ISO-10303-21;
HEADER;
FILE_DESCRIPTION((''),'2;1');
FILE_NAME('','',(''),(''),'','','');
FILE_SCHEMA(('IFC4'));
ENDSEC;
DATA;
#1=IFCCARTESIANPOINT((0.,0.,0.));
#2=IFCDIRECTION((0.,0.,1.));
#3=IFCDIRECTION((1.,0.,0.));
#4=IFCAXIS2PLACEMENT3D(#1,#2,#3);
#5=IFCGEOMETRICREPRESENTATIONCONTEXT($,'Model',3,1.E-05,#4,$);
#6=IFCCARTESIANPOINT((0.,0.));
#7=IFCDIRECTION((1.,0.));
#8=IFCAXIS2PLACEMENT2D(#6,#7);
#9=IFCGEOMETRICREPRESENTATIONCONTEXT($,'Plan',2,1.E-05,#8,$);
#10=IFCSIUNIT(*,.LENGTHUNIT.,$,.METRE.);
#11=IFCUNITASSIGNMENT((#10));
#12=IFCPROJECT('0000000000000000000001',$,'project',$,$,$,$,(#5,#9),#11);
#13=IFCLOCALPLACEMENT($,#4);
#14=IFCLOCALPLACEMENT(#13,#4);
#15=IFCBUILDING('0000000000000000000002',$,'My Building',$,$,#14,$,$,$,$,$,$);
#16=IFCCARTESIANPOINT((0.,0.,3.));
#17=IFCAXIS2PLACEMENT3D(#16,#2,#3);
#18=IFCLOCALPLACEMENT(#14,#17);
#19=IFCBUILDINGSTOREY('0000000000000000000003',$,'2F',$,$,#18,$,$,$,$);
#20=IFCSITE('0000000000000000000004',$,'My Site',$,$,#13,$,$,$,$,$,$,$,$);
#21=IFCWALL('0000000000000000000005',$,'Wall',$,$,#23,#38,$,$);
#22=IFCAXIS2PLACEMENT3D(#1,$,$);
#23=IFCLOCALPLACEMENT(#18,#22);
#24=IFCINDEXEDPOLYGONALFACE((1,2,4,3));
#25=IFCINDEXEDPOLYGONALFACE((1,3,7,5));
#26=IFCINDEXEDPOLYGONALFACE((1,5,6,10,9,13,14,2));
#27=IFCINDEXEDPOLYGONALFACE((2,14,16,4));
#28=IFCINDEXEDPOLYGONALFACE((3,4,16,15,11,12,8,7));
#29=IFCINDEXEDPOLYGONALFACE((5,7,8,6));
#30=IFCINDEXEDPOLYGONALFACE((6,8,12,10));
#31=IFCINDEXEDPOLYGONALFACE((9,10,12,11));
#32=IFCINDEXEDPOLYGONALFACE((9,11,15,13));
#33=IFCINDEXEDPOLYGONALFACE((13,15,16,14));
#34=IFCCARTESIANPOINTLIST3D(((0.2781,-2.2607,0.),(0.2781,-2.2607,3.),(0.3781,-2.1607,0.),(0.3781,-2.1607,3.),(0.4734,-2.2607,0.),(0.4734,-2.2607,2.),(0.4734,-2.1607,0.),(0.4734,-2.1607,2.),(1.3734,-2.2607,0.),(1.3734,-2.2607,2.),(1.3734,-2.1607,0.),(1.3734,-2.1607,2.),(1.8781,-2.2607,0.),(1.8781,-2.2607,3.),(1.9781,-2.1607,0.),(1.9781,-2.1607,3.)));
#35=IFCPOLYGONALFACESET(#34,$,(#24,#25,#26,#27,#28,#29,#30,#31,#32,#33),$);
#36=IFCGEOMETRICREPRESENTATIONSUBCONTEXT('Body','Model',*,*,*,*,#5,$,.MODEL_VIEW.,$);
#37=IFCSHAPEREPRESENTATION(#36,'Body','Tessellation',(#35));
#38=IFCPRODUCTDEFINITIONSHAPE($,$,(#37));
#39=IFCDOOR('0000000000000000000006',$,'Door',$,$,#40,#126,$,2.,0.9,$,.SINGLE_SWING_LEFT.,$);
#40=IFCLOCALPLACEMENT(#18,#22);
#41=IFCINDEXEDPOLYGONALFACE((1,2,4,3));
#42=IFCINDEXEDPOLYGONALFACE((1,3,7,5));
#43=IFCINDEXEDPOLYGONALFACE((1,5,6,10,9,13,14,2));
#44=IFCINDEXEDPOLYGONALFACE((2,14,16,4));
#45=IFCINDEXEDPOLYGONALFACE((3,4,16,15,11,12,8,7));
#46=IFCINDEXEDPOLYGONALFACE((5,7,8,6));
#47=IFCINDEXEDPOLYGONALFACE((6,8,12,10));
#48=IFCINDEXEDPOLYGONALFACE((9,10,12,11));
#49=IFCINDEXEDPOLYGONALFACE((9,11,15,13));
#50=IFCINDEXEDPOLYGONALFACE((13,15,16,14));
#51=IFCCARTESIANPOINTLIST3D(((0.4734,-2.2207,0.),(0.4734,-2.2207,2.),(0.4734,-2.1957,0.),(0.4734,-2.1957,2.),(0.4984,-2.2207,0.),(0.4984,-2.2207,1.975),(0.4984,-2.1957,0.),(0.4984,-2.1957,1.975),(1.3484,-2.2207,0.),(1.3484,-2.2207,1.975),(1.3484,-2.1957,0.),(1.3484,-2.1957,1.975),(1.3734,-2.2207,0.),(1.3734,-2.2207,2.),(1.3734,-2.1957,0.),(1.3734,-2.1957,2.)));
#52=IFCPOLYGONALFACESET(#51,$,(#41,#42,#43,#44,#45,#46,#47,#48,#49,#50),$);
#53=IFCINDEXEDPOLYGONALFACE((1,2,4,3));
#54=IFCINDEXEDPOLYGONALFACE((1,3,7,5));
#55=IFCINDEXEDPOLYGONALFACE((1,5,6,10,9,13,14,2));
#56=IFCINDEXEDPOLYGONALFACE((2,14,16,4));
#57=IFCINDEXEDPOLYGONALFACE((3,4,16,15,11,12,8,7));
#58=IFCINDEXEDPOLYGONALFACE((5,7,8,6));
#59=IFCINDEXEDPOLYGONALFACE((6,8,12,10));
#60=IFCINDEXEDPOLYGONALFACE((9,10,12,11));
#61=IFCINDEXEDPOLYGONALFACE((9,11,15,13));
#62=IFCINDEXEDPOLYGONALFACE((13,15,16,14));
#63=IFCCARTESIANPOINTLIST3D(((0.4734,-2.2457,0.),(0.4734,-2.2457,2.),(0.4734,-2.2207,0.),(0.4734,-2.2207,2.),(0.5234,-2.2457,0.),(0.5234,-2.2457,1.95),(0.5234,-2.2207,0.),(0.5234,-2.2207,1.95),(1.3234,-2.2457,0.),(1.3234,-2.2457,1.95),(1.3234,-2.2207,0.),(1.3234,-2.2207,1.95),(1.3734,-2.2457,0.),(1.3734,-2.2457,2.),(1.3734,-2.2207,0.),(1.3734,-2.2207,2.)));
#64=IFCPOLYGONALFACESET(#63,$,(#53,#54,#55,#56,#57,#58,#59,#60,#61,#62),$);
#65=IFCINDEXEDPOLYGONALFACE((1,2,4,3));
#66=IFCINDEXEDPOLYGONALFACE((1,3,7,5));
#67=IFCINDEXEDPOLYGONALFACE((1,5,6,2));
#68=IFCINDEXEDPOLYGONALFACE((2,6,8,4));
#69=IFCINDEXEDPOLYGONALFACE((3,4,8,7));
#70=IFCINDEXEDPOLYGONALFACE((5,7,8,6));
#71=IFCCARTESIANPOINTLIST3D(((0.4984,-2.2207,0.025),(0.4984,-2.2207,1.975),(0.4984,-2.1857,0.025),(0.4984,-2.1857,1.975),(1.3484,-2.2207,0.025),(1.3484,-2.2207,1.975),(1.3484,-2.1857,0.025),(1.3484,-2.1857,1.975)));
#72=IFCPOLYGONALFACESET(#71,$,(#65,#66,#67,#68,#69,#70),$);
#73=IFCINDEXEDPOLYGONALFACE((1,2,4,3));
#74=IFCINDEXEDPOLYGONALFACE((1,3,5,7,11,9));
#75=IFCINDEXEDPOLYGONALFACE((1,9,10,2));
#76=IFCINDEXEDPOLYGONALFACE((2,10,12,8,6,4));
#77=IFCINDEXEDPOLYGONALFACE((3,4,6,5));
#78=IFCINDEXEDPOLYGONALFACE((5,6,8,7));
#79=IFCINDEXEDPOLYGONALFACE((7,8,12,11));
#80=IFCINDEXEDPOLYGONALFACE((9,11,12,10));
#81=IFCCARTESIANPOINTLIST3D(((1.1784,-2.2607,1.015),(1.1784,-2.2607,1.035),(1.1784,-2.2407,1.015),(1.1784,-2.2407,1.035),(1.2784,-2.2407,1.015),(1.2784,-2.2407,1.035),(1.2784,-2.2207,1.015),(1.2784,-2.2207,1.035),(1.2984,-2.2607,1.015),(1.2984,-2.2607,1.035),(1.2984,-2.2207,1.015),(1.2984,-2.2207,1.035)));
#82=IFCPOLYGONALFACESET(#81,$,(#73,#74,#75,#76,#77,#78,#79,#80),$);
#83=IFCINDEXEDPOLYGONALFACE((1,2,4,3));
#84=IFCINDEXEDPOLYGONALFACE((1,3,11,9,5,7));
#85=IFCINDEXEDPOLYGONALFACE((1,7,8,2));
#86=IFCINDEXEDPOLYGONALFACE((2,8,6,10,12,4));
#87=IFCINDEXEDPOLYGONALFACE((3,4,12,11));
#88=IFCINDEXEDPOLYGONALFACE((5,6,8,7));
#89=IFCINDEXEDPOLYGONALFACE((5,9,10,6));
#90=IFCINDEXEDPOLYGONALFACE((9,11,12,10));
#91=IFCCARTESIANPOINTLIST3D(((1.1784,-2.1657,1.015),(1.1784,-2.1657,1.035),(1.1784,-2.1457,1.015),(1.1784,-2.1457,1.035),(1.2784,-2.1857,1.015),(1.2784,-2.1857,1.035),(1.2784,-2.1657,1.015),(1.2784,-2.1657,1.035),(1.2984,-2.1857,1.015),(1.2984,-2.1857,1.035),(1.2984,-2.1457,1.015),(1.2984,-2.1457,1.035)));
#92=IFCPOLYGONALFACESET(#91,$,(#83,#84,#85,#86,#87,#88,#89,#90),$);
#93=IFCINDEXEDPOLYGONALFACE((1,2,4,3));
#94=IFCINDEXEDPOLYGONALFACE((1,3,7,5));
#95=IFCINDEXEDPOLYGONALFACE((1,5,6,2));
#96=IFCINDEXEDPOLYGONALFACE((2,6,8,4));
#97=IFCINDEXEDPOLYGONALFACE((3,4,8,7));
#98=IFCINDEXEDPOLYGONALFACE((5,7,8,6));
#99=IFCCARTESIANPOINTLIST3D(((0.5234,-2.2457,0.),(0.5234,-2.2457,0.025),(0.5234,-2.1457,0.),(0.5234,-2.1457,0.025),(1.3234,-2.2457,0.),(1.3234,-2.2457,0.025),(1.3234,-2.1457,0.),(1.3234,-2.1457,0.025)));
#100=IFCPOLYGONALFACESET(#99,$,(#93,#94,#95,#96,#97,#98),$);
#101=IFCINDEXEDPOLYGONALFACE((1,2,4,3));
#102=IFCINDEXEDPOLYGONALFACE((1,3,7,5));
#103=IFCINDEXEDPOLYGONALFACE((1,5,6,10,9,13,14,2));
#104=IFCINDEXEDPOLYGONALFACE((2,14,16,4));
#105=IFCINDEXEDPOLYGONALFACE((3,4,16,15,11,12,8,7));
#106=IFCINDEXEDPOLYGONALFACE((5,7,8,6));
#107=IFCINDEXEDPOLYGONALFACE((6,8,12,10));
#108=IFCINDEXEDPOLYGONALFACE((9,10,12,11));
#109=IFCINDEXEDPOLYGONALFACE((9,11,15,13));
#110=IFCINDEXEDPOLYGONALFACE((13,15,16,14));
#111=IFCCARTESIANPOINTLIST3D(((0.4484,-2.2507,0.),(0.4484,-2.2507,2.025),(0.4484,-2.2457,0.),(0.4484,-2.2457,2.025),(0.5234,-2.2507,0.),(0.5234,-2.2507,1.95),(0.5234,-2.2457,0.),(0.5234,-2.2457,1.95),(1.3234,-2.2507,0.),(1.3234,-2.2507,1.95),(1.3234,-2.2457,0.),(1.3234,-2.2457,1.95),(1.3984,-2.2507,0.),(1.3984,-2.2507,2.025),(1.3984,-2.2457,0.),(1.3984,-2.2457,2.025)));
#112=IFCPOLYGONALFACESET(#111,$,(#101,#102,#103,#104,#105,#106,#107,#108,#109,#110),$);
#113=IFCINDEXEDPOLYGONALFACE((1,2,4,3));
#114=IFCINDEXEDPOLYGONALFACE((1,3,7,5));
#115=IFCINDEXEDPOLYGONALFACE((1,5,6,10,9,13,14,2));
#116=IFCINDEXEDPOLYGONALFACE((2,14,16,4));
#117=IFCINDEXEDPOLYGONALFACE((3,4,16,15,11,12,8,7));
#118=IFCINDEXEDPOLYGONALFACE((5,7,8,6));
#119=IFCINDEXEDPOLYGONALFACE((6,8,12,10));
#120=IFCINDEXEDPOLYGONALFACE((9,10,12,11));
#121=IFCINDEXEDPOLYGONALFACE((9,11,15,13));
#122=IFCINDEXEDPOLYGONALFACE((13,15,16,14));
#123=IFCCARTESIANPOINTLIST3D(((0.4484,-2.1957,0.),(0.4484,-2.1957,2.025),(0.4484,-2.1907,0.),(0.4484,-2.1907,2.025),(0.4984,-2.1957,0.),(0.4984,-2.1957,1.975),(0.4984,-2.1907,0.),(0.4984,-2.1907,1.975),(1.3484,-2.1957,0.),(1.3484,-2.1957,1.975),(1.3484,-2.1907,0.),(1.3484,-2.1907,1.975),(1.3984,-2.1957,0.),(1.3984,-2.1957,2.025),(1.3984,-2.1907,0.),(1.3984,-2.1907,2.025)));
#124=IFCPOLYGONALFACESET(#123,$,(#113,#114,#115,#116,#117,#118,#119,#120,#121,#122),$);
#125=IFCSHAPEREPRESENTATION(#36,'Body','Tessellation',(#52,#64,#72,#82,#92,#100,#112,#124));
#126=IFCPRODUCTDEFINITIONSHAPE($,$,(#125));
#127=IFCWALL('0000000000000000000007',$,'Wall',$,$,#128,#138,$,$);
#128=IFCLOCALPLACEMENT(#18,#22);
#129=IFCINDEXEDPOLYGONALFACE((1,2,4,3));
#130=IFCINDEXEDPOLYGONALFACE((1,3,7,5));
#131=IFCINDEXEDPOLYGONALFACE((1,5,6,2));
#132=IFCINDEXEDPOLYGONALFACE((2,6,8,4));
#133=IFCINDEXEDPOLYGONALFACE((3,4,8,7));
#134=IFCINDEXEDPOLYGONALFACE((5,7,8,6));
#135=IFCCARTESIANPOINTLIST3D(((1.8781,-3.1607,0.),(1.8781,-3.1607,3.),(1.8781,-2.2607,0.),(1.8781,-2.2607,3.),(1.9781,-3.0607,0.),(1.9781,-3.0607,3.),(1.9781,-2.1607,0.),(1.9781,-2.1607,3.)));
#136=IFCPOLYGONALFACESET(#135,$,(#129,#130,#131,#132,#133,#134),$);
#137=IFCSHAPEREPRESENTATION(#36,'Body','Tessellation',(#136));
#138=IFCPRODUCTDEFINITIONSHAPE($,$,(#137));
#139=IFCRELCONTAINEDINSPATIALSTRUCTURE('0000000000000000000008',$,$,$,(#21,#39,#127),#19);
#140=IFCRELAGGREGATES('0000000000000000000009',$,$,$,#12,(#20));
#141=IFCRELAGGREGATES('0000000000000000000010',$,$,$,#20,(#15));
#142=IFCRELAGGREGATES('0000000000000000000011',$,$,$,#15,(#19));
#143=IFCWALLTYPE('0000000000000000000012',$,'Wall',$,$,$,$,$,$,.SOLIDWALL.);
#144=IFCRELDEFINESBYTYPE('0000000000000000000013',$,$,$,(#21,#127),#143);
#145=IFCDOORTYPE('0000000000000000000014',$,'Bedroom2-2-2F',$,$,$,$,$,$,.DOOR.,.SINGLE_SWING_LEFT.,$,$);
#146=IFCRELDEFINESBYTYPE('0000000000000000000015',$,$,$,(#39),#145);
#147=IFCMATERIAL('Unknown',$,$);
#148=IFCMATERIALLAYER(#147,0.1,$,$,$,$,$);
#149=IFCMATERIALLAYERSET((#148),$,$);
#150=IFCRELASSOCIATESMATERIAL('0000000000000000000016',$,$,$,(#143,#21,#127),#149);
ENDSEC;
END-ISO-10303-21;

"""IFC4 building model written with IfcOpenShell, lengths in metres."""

from ifc_helpers import new_model, entity, si_unit, frame, origin_with_axes, origin_2d_with_axis, place, context, subcontext, project, spatial, line, indexed_curve, outline, extrude, shape, source, transform, mapped, material, layer, layer_set, layer_usage, type_object, type_shapes, element, fill, save


model = new_model("IFC4")

# Units and contexts
model_context = context("Model", 3, precision=1e-05, world=origin_with_axes())
plan_context = context("Plan", 2, precision=1e-05, world=origin_2d_with_axis())
body_context_1 = subcontext(model_context, "Body", "Model", "MODEL_VIEW")
body_context_2 = subcontext(plan_context, "Body", "Plan", "PLAN_VIEW")
ifc_project = project(units=[si_unit("LENGTHUNIT", "METRE")], contexts=[model_context, plan_context])

# Site, building, storey
site_placement = place(None, origin_with_axes())
site = spatial("IfcSite", under=ifc_project, at=site_placement, Name="My Site")
building_placement = place(site_placement, origin_with_axes())
building = spatial("IfcBuilding", under=site, at=building_placement, Name="My Building")
storey_placement = place(building_placement, frame((0.0, 0.0, 3.0), z_axis=(0.0, 0.0, 1.0), x_axis=(1.0, 0.0, 0.0)))
storey = spatial("IfcBuildingStorey", under=building, at=storey_placement, Name="2F")

# Shared definitions
ifc_material = material(Name="Unknown")
ifc_layer = layer(ifc_material, 0.1)
ifc_layer_set = layer_set([ifc_layer])
wall_type = type_object("IfcWallType", Name="Wall", PredefinedType="SOLIDWALL", material=ifc_layer_set)

# Wall, opening, door
ifc_layer_usage_1 = layer_usage(ifc_layer_set, "AXIS2", "POSITIVE", 0.0)
wall_1_placement = place(storey_placement, frame((0.2781, -2.2607, 0.0), z_axis=(0.0, 0.0, 1.0), x_axis=(1.0, 0.0, 0.0)))
wall_1 = element("IfcWall", 1, at=wall_1_placement, inside=storey, type_object=wall_type, material=ifc_layer_usage_1, Name="Wall", context=body_context_1, shape_type="SweptSolid", body=[
    extrude(outline(indexed_curve([(0.0, 0.0), (0.1, 0.1), (1.7, 0.1), (1.6, 0.0)], segments=[line(1, 2, 3, 4, 1)])), origin_with_axes(), (0.0, 0.0, 1.0), 3.0),
])
shared_shape_1 = source(origin_with_axes(), body_context_1, "Body", "SweptSolid", [
    extrude(outline(indexed_curve([(0.0, 0.0), (0.9, 0.0), (0.9, 2.0), (0.0, 2.0)], segments=[line(1, 2, 3, 4, 1)])), frame((0.0, -0.6, 0.0), z_axis=(0.0, -1.0, 0.0), x_axis=(1.0, 0.0, 0.0)), (0.0, 0.0, -1.0), 1.2),
])
opening_1_placement = place(wall_1_placement, frame((0.1952, 0.015, 0.0), z_axis=(0.0, 0.0, 1.0), x_axis=(1.0, 0.0, 0.0)))
opening_1 = element("IfcOpeningElement", 2, at=opening_1_placement, cuts=wall_1, PredefinedType="OPENING", context=body_context_1, shape_type="MappedRepresentation", body=[
    mapped(shared_shape_1, transform((0.0, 0.0, 0.0), x_axis=(1.0, 0.0, 0.0), y_axis=(0.0, 1.0, 0.0), z_axis=(0.0, 0.0, 1.0), scale=1.0)),
])
door_type_1 = type_object("IfcDoorType", Name="Bedroom2-2-2F", OperationType="SINGLE_SWING_LEFT", PredefinedType="DOOR")
shared_shape_2 = source(origin_with_axes(), body_context_1, "Body", "SweptSolid", [
    extrude(outline(indexed_curve([(0.0, 0.0), (0.0, 2.0), (0.9, 2.0), (0.9, 0.0), (0.875, 0.0), (0.875, 1.975), (0.025, 1.975), (0.025, 0.0)], segments=[line(1, 2, 3, 4, 5, 6, 7, 8, 1)])), frame((0.0, 0.025, 0.0), z_axis=(0.0, -1.0, 0.0), x_axis=(1.0, 0.0, 0.0)), (0.0, 0.0, -1.0), 0.025),
    extrude(outline(indexed_curve([(0.0, 0.0), (0.0, 2.0), (0.9, 2.0), (0.9, 0.0), (0.85, 0.0), (0.85, 1.95), (0.05, 1.95), (0.05, 0.0)], segments=[line(1, 2, 3, 4, 5, 6, 7, 8, 1)])), frame((0.0, 0.0, 0.0), z_axis=(0.0, -1.0, 0.0), x_axis=(1.0, 0.0, 0.0)), (0.0, 0.0, -1.0), 0.025),
    extrude(outline(indexed_curve([(0.0, 0.0), (0.85, 0.0), (0.85, 0.035), (0.0, 0.035)], segments=[line(1, 2, 3, 4, 1)])), frame((0.025, 0.025, 0.025), z_axis=(0.0, 0.0, 1.0), x_axis=(1.0, 0.0, 0.0)), (0.0, 0.0, 1.0), 1.95),
    extrude(outline(indexed_curve([(0.0, 0.0), (0.0, -0.04), (-0.12, -0.04), (-0.12, -0.02), (-0.02, -0.02), (-0.02, 0.0)], segments=[line(1, 2, 3, 4, 5, 6, 1)])), frame((0.825, 0.025, 1.015), z_axis=(0.0, 0.0, 1.0), x_axis=(1.0, 0.0, 0.0)), (0.0, 0.0, 1.0), 0.02),
    extrude(outline(indexed_curve([(0.0, 0.0), (0.0, 0.04), (-0.12, 0.04), (-0.12, 0.02), (-0.02, 0.02), (-0.02, 0.0)], segments=[line(1, 2, 3, 4, 5, 6, 1)])), frame((0.825, 0.06, 1.015), z_axis=(0.0, 0.0, 1.0), x_axis=(1.0, 0.0, 0.0)), (0.0, 0.0, 1.0), 0.02),
    extrude(outline(indexed_curve([(0.0, 0.0), (0.8, 0.0), (0.8, 0.1), (0.0, 0.1)], segments=[line(1, 2, 3, 4, 1)])), frame((0.05, 0.0, 0.0), z_axis=(0.0, 0.0, 1.0), x_axis=(1.0, 0.0, 0.0)), (0.0, 0.0, 1.0), 0.025),
    extrude(outline(indexed_curve([(0.0, 0.0), (0.0, 2.025), (0.95, 2.025), (0.95, 0.0), (0.875, 0.0), (0.875, 1.95), (0.075, 1.95), (0.075, 0.0)], segments=[line(1, 2, 3, 4, 5, 6, 7, 8, 1)])), frame((-0.025, -0.005, 0.0), z_axis=(0.0, -1.0, 0.0), x_axis=(1.0, 0.0, 0.0)), (0.0, 0.0, -1.0), 0.005),
    extrude(outline(indexed_curve([(0.0, 0.0), (0.0, 2.025), (0.95, 2.025), (0.95, 0.0), (0.9, 0.0), (0.9, 1.975), (0.05, 1.975), (0.05, 0.0)], segments=[line(1, 2, 3, 4, 5, 6, 7, 8, 1)])), frame((-0.025, 0.05, 0.0), z_axis=(0.0, -1.0, 0.0), x_axis=(1.0, 0.0, 0.0)), (0.0, 0.0, -1.0), 0.005),
])
shared_shape_3 = source(origin_with_axes(), body_context_2, "Body", "Curve2D", [
    entity("IfcIndexedPolyCurve", entity("IfcCartesianPointList2D", [[0.0, 0.0], [0.0, 0.05], [0.025, 0.05], [0.025, 0.025], [0.05, 0.025], [0.05, 0.0]]), [entity("IfcLineIndex", [1, 2, 3, 4, 5, 6, 1])]),
    entity("IfcIndexedPolyCurve", entity("IfcCartesianPointList2D", [[0.9, 0.0], [0.9, 0.05], [0.875, 0.05], [0.875, 0.025], [0.85, 0.025], [0.85, 0.0]]), [entity("IfcLineIndex", [1, 2, 3, 4, 5, 6, 1])]),
    entity("IfcTrimmedCurve", entity("IfcEllipse", entity("IfcAxis2Placement2D", entity("IfcCartesianPoint", [0.06, 0.05]), entity("IfcDirection", [1.0, 0.0])), 0.815, 0.85), [entity("IfcCartesianPoint", [0.875, 0.05])], [entity("IfcCartesianPoint", [0.06, 0.9])], True, "CARTESIAN"),
    entity("IfcIndexedPolyCurve", entity("IfcCartesianPointList2D", [[0.025, 0.05], [0.06, 0.05], [0.06, 0.9], [0.025, 0.9]]), [entity("IfcLineIndex", [1, 2, 3, 4, 1])]),
])
type_shapes(door_type_1, [shared_shape_2, shared_shape_3])
door_1_placement = place(opening_1_placement, frame((0.0, 0.0, 0.0), z_axis=(0.0, 0.0, 1.0), x_axis=(1.0, 0.0, 0.0)))
door_1 = element("IfcDoor", 3, at=door_1_placement, inside=storey, type_object=door_type_1, Name="Door", OperationType="SINGLE_SWING_LEFT", OverallHeight=2.0, OverallWidth=0.9, shapes=[
    shape(body_context_1, "Body", "MappedRepresentation", [mapped(shared_shape_2, transform((0.0, 0.0, 0.0), x_axis=(1.0, 0.0, 0.0), y_axis=(0.0, 1.0, 0.0), z_axis=(0.0, 0.0, 1.0), scale=1.0))]),
    shape(body_context_2, "Body", "MappedRepresentation", [mapped(shared_shape_3, transform((0.0, 0.0, 0.0), x_axis=(1.0, 0.0, 0.0), y_axis=(0.0, 1.0, 0.0), z_axis=(0.0, 0.0, 1.0), scale=1.0))]),
])
fill(opening_1, door_1)

# Wall
ifc_layer_usage_2 = layer_usage(ifc_layer_set, "AXIS2", "POSITIVE", 0.0)
wall_2_placement = place(storey_placement, frame((1.8781, -2.2607, 0.0), z_axis=(0.0, 0.0, 1.0), x_axis=(0.0, -1.0, 0.0)))
element("IfcWall", 4, at=wall_2_placement, inside=storey, type_object=wall_type, material=ifc_layer_usage_2, Name="Wall", context=body_context_1, shape_type="SweptSolid", body=[
    extrude(outline(indexed_curve([(0.0, 0.0), (-0.1, 0.1), (0.8, 0.1), (0.9, 0.0)], segments=[line(1, 2, 3, 4, 1)])), origin_with_axes(), (0.0, 0.0, 1.0), 3.0),
])

save(model, "model.ifc")
